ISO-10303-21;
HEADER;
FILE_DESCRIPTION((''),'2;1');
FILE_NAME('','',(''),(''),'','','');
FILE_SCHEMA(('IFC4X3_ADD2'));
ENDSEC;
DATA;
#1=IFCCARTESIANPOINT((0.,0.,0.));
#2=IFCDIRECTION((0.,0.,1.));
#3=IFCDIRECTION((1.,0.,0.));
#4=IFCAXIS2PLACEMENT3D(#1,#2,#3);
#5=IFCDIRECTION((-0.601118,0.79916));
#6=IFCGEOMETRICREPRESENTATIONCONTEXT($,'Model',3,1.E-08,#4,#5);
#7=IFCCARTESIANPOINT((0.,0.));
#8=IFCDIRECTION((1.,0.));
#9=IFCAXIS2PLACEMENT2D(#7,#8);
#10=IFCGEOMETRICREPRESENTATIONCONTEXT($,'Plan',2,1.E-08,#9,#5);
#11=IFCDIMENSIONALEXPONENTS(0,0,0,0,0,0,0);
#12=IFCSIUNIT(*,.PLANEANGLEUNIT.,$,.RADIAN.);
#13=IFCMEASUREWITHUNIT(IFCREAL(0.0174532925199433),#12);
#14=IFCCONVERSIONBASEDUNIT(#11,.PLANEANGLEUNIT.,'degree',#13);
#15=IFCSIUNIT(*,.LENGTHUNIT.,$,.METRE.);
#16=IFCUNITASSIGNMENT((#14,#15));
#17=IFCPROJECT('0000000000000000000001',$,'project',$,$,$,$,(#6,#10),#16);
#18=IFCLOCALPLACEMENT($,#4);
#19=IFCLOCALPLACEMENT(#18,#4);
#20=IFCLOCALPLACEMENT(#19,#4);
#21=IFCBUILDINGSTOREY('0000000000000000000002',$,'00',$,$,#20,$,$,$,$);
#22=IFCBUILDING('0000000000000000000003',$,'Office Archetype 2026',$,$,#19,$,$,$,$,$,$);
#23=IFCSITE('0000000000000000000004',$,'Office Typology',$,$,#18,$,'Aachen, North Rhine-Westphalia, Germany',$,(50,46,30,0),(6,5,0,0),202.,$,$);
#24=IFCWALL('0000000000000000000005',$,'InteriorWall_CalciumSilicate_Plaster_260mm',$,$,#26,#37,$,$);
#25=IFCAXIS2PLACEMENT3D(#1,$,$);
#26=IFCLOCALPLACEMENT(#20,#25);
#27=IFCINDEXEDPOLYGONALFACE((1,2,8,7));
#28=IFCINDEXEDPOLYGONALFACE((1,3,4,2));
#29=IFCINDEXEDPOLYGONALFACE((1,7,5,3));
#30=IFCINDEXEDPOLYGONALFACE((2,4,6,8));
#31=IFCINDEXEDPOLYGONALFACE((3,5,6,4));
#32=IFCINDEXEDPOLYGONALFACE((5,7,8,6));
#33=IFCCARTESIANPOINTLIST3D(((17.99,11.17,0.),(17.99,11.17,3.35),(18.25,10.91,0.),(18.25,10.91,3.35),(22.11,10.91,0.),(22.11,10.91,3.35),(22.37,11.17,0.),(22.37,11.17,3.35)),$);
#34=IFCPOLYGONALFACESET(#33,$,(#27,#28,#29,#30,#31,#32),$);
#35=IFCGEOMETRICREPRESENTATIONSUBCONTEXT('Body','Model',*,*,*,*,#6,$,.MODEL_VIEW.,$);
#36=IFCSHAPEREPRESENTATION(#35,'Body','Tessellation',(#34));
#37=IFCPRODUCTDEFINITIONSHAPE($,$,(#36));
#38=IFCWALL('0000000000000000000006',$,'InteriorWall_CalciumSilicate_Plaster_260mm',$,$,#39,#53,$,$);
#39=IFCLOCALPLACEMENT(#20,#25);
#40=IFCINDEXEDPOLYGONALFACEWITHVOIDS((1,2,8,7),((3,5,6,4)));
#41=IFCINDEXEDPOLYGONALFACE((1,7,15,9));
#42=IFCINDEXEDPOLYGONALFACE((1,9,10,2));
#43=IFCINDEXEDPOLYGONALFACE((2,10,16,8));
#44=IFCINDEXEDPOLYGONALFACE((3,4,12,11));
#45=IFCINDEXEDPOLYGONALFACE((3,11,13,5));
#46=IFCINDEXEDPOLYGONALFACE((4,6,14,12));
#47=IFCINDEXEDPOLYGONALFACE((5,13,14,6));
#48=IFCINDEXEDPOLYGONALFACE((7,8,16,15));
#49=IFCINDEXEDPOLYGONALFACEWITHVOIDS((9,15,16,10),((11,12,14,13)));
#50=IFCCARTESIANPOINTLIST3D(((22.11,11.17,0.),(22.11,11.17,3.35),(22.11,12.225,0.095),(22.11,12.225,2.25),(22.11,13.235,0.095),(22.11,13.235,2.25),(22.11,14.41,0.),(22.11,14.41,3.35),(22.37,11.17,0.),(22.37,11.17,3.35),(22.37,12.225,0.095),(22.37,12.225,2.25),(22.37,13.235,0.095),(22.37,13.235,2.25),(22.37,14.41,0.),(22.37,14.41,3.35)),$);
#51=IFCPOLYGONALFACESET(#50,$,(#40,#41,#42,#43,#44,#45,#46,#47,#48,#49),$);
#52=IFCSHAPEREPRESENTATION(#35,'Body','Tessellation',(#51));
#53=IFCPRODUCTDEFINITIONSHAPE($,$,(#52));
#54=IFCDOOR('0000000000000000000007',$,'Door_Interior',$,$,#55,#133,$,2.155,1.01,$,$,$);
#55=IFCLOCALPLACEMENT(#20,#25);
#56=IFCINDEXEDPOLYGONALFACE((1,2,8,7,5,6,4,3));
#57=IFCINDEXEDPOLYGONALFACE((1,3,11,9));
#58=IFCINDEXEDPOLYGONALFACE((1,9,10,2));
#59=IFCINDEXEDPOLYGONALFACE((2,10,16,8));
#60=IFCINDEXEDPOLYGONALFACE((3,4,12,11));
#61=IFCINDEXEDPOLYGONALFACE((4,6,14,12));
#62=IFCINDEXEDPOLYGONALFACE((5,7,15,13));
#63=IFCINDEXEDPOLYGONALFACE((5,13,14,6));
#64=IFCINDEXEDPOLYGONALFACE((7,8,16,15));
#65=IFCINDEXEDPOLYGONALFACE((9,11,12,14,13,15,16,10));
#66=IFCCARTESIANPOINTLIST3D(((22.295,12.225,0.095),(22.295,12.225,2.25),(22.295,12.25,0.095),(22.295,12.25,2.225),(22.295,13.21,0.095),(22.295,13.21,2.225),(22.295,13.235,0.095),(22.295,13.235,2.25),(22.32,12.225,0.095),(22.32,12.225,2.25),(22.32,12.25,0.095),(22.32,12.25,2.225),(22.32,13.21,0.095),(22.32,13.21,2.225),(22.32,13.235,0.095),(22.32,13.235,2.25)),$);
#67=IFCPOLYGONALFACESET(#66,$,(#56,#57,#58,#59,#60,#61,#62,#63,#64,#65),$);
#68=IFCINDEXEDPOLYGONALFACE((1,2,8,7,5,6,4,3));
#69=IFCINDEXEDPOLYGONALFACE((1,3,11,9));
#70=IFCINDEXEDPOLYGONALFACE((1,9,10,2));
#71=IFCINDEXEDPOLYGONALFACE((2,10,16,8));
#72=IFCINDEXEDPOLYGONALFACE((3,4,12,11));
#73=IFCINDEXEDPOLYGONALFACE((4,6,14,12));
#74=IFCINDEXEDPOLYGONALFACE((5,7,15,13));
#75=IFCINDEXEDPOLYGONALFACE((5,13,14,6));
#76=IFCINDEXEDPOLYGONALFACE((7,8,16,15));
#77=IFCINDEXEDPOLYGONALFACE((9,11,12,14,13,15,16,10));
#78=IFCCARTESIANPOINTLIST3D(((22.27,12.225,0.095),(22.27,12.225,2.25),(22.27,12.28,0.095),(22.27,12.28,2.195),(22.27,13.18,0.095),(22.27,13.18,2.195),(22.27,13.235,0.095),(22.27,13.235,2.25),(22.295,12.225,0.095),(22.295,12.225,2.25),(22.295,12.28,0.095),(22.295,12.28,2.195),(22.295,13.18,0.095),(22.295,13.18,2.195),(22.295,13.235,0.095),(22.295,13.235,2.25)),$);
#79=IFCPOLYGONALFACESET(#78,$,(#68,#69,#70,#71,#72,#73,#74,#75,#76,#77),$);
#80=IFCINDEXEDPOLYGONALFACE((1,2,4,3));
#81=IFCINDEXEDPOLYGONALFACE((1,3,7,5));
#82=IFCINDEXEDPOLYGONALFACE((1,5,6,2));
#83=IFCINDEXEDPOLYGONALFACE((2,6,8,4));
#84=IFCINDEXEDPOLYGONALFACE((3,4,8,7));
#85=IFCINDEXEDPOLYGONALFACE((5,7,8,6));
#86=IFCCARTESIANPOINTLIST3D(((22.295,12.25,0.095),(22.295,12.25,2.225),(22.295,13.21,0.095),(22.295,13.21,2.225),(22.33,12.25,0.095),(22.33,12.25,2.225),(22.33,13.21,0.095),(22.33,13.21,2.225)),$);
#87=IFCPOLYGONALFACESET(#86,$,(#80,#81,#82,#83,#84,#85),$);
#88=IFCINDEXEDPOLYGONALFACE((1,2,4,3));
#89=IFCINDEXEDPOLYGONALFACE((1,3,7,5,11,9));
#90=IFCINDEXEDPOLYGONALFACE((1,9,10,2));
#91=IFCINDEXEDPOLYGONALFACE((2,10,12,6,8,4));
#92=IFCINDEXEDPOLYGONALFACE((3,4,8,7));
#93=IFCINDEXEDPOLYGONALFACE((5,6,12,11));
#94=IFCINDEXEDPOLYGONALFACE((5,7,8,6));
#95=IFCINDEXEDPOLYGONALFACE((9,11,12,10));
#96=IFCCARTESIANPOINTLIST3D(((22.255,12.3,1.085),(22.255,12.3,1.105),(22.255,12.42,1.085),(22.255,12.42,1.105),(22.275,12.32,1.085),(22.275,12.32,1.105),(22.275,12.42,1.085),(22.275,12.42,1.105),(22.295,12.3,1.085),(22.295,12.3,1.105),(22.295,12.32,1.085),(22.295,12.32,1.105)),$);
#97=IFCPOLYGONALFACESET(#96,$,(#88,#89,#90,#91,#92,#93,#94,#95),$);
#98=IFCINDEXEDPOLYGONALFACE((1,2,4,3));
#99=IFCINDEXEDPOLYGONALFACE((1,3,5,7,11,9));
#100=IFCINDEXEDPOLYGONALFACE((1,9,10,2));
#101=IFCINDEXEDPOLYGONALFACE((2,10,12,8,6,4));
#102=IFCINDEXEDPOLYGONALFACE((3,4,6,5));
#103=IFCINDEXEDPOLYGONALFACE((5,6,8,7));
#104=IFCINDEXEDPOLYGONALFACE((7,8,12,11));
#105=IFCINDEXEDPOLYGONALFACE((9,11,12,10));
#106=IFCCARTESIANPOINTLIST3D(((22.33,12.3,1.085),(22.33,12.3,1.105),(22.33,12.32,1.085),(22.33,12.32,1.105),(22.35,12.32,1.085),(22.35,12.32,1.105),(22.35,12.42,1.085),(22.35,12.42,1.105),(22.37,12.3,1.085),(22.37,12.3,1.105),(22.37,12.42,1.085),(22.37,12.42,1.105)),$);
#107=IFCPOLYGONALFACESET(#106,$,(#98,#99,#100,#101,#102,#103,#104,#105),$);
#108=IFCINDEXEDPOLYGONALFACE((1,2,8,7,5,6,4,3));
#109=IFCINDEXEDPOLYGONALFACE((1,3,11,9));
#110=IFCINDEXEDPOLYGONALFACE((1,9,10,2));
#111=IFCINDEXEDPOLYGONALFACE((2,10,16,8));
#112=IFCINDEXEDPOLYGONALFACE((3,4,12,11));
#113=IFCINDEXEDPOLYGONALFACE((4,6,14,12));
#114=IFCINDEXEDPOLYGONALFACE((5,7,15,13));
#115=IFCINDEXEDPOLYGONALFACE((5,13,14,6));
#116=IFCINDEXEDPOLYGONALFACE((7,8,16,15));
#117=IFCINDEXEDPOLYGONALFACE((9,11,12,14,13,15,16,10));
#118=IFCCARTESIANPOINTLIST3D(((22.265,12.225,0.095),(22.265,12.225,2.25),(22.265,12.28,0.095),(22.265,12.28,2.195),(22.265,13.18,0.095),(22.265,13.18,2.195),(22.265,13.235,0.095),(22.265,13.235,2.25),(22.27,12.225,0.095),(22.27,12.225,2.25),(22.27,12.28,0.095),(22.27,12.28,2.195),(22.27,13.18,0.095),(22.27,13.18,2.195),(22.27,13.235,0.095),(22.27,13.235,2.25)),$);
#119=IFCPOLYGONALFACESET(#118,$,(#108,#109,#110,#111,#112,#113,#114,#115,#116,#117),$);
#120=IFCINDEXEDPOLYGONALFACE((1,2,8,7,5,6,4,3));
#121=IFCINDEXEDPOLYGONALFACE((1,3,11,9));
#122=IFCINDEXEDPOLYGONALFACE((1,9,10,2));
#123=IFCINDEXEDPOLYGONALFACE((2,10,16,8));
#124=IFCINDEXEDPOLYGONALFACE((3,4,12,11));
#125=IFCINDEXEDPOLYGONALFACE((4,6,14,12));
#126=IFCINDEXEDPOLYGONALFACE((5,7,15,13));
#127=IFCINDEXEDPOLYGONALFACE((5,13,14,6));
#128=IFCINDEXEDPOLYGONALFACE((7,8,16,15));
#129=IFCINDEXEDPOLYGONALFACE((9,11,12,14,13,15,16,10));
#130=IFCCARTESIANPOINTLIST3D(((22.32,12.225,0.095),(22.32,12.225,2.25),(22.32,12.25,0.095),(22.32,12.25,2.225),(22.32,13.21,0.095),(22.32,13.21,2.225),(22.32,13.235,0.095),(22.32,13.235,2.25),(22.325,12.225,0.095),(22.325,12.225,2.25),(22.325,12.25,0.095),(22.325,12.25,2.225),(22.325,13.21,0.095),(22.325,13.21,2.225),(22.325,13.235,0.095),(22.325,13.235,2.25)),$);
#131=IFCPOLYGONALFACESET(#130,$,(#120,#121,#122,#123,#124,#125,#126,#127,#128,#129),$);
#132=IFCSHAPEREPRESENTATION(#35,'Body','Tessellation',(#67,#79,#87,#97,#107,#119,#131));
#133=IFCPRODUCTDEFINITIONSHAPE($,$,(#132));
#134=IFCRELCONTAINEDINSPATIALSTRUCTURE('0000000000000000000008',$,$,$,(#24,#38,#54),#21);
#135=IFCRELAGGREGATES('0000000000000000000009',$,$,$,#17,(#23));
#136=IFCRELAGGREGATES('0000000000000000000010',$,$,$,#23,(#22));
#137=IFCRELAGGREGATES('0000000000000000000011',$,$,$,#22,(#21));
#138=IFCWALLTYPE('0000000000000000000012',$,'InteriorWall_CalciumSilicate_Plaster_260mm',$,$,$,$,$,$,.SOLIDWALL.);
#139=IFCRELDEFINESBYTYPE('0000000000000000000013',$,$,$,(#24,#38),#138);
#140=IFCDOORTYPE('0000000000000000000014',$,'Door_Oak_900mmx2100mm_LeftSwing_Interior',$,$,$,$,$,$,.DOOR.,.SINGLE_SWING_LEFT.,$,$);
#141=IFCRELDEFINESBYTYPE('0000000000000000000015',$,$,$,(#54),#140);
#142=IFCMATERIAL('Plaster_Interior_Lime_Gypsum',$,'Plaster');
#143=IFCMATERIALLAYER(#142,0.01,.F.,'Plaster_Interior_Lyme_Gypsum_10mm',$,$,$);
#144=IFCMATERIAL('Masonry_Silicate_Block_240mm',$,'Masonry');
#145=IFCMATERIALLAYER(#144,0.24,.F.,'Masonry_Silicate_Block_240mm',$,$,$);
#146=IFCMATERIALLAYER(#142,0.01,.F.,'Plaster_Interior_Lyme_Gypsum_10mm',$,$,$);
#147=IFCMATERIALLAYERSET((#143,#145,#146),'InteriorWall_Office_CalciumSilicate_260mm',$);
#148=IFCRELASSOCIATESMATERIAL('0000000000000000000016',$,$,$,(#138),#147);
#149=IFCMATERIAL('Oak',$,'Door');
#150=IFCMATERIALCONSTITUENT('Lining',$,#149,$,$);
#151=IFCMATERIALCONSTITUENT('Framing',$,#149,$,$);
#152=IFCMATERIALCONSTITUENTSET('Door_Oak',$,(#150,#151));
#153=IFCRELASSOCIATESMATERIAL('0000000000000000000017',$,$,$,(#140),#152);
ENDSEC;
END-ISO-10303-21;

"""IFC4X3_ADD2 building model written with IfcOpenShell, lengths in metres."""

from ifc_helpers import new_model, entity, si_unit, converted_unit, direction, frame, origin_with_axes, origin_2d_with_axis, place, context, subcontext, project, spatial, line, indexed_curve, outline, extrude, source, transform, mapped, material, layer, layer_set, constituent, constituent_set, type_object, type_shapes, element, fill, save


model = new_model("IFC4X3_ADD2")

# Units and contexts
model_context = context("Model", 3, precision=1e-08, world=origin_with_axes(), true_north=direction((-0.601118, 0.79916)))
plan_context = context("Plan", 2, precision=1e-08, world=origin_2d_with_axis(), true_north=direction((-0.601118, 0.79916)))
body_context = subcontext(model_context, "Body", "Model", "MODEL_VIEW")
ifc_project = project(units=[converted_unit("PLANEANGLEUNIT", "degree", entity("IfcReal", 0.0174532925199433), si_unit("PLANEANGLEUNIT", "RADIAN"), dimensions=[0, 0, 0, 0, 0, 0, 0]), si_unit("LENGTHUNIT", "METRE")], contexts=[model_context, plan_context])

# Site, building, storey
site_placement = place(None, origin_with_axes())
site = spatial("IfcSite", under=ifc_project, at=site_placement, Name="Office Typology", LongName="Aachen, North Rhine-Westphalia, Germany", RefLatitude=(50, 46, 30, 0), RefLongitude=(6, 5, 0, 0), RefElevation=202.0)
building_placement = place(site_placement, origin_with_axes())
building = spatial("IfcBuilding", under=site, at=building_placement, Name="Office Archetype 2026")
storey_placement = place(building_placement, origin_with_axes())
storey = spatial("IfcBuildingStorey", under=building, at=storey_placement, Name="00")

# Wall
ifc_material_1 = material(Name="Plaster_Interior_Lime_Gypsum", Category="Plaster")
ifc_layer_1 = layer(ifc_material_1, 0.01, ventilated=False, Name="Plaster_Interior_Lyme_Gypsum_10mm")
ifc_material_2 = material(Name="Masonry_Silicate_Block_240mm", Category="Masonry")
ifc_layer_2 = layer(ifc_material_2, 0.24, ventilated=False, Name="Masonry_Silicate_Block_240mm")
ifc_layer_3 = layer(ifc_material_1, 0.01, ventilated=False, Name="Plaster_Interior_Lyme_Gypsum_10mm")
ifc_layer_set = layer_set([ifc_layer_1, ifc_layer_2, ifc_layer_3], Name="InteriorWall_Office_CalciumSilicate_260mm")
wall_type = type_object("IfcWallType", Name="InteriorWall_CalciumSilicate_Plaster_260mm", PredefinedType="SOLIDWALL", material=ifc_layer_set)
wall_1_placement = place(storey_placement, frame((22.37, 11.17, 0.0), z_axis=(0.0, 0.0, 1.0), x_axis=(-1.0, 0.0, 0.0)))
element("IfcWall", 1, at=wall_1_placement, inside=storey, type_object=wall_type, Name="InteriorWall_CalciumSilicate_Plaster_260mm", context=body_context, shape_type="SweptSolid", body=[
    extrude(outline(indexed_curve([(0.0, 0.0), (0.26, 0.26), (4.12, 0.26), (4.38, 0.0)], segments=[line(1, 2, 3, 4, 1)])), origin_with_axes(), (0.0, 0.0, 1.0), 3.35),
])

# Wall, opening, door
wall_2_placement = place(storey_placement, frame((22.37, 11.17, 0.0), z_axis=(0.0, 0.0, 1.0), x_axis=(0.0, 1.0, 0.0)))
wall_2 = element("IfcWall", 2, at=wall_2_placement, inside=storey, type_object=wall_type, Name="InteriorWall_CalciumSilicate_Plaster_260mm", context=body_context, shape_type="SweptSolid", body=[
    extrude(outline(indexed_curve([(0.0, 0.0), (0.0, 0.26), (3.24, 0.26), (3.24, 0.0)], segments=[line(1, 2, 3, 4, 1)])), origin_with_axes(), (0.0, 0.0, 1.0), 3.35),
])
shared_shape_1 = source(origin_with_axes(), body_context, "Body", "SweptSolid", [
    extrude(outline(indexed_curve([(0.0, 2.155), (1.01, 2.155), (1.01, 0.0), (0.0, 0.0), (0.0, 2.155)])), frame((0.0, -0.015, 0.0), z_axis=(0.0, -1.0, 0.0), x_axis=(1.0, 0.0, 0.0)), (0.0, 0.0, -1.0), 0.26),
])
opening_1_placement = place(wall_2_placement, frame((2.065, 0.245, 0.095), z_axis=(0.0, 0.0, 1.0), x_axis=(-1.0, 0.0, 0.0)))
opening_1 = element("IfcOpeningElement", 3, at=opening_1_placement, cuts=wall_2, PredefinedType="OPENING", context=body_context, shape_type="MappedRepresentation", body=[
    mapped(shared_shape_1, transform((0.0, 0.0, 0.0), x_axis=(1.0, 0.0, 0.0), y_axis=(0.0, 1.0, 0.0), z_axis=(0.0, 0.0, 1.0), scale=1.0)),
])
ifc_material_3 = material(Name="Oak", Category="Door")
ifc_constituent_1 = constituent(ifc_material_3, Name="Lining")
ifc_constituent_2 = constituent(ifc_material_3, Name="Framing")
ifc_constituent_set_1 = constituent_set(constituents=[ifc_constituent_1, ifc_constituent_2], Name="Door_Oak")
door_type_1 = type_object("IfcDoorType", Name="Door_Oak_900mmx2100mm_LeftSwing_Interior", OperationType="SINGLE_SWING_LEFT", PredefinedType="DOOR", material=ifc_constituent_set_1)
shared_shape_2 = source(origin_with_axes(), body_context, "Body", "SweptSolid", [
    extrude(outline(indexed_curve([(0.0, 0.0), (0.0, 2.155), (1.01, 2.155), (1.01, 0.0), (0.985, 0.0), (0.985, 2.13), (0.025, 2.13), (0.025, 0.0)], segments=[line(1, 2, 3, 4, 5, 6, 7, 8, 1)])), frame((0.0, 0.025, 0.0), z_axis=(0.0, -1.0, 0.0), x_axis=(1.0, 0.0, 0.0)), (0.0, 0.0, -1.0), 0.025),
    extrude(outline(indexed_curve([(0.0, 0.0), (0.0, 2.155), (1.01, 2.155), (1.01, 0.0), (0.955, 0.0), (0.955, 2.1), (0.055, 2.1), (0.055, 0.0)], segments=[line(1, 2, 3, 4, 5, 6, 7, 8, 1)])), frame((0.0, 0.0, 0.0), z_axis=(0.0, -1.0, 0.0), x_axis=(1.0, 0.0, 0.0)), (0.0, 0.0, -1.0), 0.025),
    extrude(outline(indexed_curve([(0.0, 0.0), (0.96, 0.0), (0.96, 0.035), (0.0, 0.035)], segments=[line(1, 2, 3, 4, 1)])), frame((0.025, 0.025, 0.0), z_axis=(0.0, 0.0, 1.0), x_axis=(1.0, 0.0, 0.0)), (0.0, 0.0, 1.0), 2.13),
    extrude(outline(indexed_curve([(0.0, 0.0), (0.0, -0.04), (-0.12, -0.04), (-0.12, -0.02), (-0.02, -0.02), (-0.02, 0.0)], segments=[line(1, 2, 3, 4, 5, 6, 1)])), frame((0.935, 0.025, 0.99), z_axis=(0.0, 0.0, 1.0), x_axis=(1.0, 0.0, 0.0)), (0.0, 0.0, 1.0), 0.02),
    extrude(outline(indexed_curve([(0.0, 0.0), (0.0, 0.04), (-0.12, 0.04), (-0.12, 0.02), (-0.02, 0.02), (-0.02, 0.0)], segments=[line(1, 2, 3, 4, 5, 6, 1)])), frame((0.935, 0.06, 0.99), z_axis=(0.0, 0.0, 1.0), x_axis=(1.0, 0.0, 0.0)), (0.0, 0.0, 1.0), 0.02),
    extrude(outline(indexed_curve([(0.0, 0.0), (0.0, 2.155), (1.01, 2.155), (1.01, 0.0), (0.955, 0.0), (0.955, 2.1), (0.055, 2.1), (0.055, 0.0)], segments=[line(1, 2, 3, 4, 5, 6, 7, 8, 1)])), frame((0.0, -0.005, 0.0), z_axis=(0.0, -1.0, 0.0), x_axis=(1.0, 0.0, 0.0)), (0.0, 0.0, -1.0), 0.005),
    extrude(outline(indexed_curve([(0.0, 0.0), (0.0, 2.155), (1.01, 2.155), (1.01, 0.0), (0.985, 0.0), (0.985, 2.13), (0.025, 2.13), (0.025, 0.0)], segments=[line(1, 2, 3, 4, 5, 6, 7, 8, 1)])), frame((0.0, 0.05, 0.0), z_axis=(0.0, -1.0, 0.0), x_axis=(1.0, 0.0, 0.0)), (0.0, 0.0, -1.0), 0.005),
])
type_shapes(door_type_1, [shared_shape_2])
door_1_placement = place(opening_1_placement, frame((0.0, 0.145, 0.0), z_axis=(0.0, 0.0, 1.0), x_axis=(1.0, 0.0, 0.0)))
door_1 = element("IfcDoor", 4, at=door_1_placement, inside=storey, type_object=door_type_1, Name="Door_Interior", OverallHeight=2.155, OverallWidth=1.01, context=body_context, shape_type="MappedRepresentation", body=[
    mapped(shared_shape_2, transform((0.0, 0.0, 0.0), x_axis=(1.0, 0.0, 0.0), y_axis=(0.0, 1.0, 0.0), z_axis=(0.0, 0.0, 1.0), scale=1.0)),
])
fill(opening_1, door_1)

save(model, "model.ifc")
